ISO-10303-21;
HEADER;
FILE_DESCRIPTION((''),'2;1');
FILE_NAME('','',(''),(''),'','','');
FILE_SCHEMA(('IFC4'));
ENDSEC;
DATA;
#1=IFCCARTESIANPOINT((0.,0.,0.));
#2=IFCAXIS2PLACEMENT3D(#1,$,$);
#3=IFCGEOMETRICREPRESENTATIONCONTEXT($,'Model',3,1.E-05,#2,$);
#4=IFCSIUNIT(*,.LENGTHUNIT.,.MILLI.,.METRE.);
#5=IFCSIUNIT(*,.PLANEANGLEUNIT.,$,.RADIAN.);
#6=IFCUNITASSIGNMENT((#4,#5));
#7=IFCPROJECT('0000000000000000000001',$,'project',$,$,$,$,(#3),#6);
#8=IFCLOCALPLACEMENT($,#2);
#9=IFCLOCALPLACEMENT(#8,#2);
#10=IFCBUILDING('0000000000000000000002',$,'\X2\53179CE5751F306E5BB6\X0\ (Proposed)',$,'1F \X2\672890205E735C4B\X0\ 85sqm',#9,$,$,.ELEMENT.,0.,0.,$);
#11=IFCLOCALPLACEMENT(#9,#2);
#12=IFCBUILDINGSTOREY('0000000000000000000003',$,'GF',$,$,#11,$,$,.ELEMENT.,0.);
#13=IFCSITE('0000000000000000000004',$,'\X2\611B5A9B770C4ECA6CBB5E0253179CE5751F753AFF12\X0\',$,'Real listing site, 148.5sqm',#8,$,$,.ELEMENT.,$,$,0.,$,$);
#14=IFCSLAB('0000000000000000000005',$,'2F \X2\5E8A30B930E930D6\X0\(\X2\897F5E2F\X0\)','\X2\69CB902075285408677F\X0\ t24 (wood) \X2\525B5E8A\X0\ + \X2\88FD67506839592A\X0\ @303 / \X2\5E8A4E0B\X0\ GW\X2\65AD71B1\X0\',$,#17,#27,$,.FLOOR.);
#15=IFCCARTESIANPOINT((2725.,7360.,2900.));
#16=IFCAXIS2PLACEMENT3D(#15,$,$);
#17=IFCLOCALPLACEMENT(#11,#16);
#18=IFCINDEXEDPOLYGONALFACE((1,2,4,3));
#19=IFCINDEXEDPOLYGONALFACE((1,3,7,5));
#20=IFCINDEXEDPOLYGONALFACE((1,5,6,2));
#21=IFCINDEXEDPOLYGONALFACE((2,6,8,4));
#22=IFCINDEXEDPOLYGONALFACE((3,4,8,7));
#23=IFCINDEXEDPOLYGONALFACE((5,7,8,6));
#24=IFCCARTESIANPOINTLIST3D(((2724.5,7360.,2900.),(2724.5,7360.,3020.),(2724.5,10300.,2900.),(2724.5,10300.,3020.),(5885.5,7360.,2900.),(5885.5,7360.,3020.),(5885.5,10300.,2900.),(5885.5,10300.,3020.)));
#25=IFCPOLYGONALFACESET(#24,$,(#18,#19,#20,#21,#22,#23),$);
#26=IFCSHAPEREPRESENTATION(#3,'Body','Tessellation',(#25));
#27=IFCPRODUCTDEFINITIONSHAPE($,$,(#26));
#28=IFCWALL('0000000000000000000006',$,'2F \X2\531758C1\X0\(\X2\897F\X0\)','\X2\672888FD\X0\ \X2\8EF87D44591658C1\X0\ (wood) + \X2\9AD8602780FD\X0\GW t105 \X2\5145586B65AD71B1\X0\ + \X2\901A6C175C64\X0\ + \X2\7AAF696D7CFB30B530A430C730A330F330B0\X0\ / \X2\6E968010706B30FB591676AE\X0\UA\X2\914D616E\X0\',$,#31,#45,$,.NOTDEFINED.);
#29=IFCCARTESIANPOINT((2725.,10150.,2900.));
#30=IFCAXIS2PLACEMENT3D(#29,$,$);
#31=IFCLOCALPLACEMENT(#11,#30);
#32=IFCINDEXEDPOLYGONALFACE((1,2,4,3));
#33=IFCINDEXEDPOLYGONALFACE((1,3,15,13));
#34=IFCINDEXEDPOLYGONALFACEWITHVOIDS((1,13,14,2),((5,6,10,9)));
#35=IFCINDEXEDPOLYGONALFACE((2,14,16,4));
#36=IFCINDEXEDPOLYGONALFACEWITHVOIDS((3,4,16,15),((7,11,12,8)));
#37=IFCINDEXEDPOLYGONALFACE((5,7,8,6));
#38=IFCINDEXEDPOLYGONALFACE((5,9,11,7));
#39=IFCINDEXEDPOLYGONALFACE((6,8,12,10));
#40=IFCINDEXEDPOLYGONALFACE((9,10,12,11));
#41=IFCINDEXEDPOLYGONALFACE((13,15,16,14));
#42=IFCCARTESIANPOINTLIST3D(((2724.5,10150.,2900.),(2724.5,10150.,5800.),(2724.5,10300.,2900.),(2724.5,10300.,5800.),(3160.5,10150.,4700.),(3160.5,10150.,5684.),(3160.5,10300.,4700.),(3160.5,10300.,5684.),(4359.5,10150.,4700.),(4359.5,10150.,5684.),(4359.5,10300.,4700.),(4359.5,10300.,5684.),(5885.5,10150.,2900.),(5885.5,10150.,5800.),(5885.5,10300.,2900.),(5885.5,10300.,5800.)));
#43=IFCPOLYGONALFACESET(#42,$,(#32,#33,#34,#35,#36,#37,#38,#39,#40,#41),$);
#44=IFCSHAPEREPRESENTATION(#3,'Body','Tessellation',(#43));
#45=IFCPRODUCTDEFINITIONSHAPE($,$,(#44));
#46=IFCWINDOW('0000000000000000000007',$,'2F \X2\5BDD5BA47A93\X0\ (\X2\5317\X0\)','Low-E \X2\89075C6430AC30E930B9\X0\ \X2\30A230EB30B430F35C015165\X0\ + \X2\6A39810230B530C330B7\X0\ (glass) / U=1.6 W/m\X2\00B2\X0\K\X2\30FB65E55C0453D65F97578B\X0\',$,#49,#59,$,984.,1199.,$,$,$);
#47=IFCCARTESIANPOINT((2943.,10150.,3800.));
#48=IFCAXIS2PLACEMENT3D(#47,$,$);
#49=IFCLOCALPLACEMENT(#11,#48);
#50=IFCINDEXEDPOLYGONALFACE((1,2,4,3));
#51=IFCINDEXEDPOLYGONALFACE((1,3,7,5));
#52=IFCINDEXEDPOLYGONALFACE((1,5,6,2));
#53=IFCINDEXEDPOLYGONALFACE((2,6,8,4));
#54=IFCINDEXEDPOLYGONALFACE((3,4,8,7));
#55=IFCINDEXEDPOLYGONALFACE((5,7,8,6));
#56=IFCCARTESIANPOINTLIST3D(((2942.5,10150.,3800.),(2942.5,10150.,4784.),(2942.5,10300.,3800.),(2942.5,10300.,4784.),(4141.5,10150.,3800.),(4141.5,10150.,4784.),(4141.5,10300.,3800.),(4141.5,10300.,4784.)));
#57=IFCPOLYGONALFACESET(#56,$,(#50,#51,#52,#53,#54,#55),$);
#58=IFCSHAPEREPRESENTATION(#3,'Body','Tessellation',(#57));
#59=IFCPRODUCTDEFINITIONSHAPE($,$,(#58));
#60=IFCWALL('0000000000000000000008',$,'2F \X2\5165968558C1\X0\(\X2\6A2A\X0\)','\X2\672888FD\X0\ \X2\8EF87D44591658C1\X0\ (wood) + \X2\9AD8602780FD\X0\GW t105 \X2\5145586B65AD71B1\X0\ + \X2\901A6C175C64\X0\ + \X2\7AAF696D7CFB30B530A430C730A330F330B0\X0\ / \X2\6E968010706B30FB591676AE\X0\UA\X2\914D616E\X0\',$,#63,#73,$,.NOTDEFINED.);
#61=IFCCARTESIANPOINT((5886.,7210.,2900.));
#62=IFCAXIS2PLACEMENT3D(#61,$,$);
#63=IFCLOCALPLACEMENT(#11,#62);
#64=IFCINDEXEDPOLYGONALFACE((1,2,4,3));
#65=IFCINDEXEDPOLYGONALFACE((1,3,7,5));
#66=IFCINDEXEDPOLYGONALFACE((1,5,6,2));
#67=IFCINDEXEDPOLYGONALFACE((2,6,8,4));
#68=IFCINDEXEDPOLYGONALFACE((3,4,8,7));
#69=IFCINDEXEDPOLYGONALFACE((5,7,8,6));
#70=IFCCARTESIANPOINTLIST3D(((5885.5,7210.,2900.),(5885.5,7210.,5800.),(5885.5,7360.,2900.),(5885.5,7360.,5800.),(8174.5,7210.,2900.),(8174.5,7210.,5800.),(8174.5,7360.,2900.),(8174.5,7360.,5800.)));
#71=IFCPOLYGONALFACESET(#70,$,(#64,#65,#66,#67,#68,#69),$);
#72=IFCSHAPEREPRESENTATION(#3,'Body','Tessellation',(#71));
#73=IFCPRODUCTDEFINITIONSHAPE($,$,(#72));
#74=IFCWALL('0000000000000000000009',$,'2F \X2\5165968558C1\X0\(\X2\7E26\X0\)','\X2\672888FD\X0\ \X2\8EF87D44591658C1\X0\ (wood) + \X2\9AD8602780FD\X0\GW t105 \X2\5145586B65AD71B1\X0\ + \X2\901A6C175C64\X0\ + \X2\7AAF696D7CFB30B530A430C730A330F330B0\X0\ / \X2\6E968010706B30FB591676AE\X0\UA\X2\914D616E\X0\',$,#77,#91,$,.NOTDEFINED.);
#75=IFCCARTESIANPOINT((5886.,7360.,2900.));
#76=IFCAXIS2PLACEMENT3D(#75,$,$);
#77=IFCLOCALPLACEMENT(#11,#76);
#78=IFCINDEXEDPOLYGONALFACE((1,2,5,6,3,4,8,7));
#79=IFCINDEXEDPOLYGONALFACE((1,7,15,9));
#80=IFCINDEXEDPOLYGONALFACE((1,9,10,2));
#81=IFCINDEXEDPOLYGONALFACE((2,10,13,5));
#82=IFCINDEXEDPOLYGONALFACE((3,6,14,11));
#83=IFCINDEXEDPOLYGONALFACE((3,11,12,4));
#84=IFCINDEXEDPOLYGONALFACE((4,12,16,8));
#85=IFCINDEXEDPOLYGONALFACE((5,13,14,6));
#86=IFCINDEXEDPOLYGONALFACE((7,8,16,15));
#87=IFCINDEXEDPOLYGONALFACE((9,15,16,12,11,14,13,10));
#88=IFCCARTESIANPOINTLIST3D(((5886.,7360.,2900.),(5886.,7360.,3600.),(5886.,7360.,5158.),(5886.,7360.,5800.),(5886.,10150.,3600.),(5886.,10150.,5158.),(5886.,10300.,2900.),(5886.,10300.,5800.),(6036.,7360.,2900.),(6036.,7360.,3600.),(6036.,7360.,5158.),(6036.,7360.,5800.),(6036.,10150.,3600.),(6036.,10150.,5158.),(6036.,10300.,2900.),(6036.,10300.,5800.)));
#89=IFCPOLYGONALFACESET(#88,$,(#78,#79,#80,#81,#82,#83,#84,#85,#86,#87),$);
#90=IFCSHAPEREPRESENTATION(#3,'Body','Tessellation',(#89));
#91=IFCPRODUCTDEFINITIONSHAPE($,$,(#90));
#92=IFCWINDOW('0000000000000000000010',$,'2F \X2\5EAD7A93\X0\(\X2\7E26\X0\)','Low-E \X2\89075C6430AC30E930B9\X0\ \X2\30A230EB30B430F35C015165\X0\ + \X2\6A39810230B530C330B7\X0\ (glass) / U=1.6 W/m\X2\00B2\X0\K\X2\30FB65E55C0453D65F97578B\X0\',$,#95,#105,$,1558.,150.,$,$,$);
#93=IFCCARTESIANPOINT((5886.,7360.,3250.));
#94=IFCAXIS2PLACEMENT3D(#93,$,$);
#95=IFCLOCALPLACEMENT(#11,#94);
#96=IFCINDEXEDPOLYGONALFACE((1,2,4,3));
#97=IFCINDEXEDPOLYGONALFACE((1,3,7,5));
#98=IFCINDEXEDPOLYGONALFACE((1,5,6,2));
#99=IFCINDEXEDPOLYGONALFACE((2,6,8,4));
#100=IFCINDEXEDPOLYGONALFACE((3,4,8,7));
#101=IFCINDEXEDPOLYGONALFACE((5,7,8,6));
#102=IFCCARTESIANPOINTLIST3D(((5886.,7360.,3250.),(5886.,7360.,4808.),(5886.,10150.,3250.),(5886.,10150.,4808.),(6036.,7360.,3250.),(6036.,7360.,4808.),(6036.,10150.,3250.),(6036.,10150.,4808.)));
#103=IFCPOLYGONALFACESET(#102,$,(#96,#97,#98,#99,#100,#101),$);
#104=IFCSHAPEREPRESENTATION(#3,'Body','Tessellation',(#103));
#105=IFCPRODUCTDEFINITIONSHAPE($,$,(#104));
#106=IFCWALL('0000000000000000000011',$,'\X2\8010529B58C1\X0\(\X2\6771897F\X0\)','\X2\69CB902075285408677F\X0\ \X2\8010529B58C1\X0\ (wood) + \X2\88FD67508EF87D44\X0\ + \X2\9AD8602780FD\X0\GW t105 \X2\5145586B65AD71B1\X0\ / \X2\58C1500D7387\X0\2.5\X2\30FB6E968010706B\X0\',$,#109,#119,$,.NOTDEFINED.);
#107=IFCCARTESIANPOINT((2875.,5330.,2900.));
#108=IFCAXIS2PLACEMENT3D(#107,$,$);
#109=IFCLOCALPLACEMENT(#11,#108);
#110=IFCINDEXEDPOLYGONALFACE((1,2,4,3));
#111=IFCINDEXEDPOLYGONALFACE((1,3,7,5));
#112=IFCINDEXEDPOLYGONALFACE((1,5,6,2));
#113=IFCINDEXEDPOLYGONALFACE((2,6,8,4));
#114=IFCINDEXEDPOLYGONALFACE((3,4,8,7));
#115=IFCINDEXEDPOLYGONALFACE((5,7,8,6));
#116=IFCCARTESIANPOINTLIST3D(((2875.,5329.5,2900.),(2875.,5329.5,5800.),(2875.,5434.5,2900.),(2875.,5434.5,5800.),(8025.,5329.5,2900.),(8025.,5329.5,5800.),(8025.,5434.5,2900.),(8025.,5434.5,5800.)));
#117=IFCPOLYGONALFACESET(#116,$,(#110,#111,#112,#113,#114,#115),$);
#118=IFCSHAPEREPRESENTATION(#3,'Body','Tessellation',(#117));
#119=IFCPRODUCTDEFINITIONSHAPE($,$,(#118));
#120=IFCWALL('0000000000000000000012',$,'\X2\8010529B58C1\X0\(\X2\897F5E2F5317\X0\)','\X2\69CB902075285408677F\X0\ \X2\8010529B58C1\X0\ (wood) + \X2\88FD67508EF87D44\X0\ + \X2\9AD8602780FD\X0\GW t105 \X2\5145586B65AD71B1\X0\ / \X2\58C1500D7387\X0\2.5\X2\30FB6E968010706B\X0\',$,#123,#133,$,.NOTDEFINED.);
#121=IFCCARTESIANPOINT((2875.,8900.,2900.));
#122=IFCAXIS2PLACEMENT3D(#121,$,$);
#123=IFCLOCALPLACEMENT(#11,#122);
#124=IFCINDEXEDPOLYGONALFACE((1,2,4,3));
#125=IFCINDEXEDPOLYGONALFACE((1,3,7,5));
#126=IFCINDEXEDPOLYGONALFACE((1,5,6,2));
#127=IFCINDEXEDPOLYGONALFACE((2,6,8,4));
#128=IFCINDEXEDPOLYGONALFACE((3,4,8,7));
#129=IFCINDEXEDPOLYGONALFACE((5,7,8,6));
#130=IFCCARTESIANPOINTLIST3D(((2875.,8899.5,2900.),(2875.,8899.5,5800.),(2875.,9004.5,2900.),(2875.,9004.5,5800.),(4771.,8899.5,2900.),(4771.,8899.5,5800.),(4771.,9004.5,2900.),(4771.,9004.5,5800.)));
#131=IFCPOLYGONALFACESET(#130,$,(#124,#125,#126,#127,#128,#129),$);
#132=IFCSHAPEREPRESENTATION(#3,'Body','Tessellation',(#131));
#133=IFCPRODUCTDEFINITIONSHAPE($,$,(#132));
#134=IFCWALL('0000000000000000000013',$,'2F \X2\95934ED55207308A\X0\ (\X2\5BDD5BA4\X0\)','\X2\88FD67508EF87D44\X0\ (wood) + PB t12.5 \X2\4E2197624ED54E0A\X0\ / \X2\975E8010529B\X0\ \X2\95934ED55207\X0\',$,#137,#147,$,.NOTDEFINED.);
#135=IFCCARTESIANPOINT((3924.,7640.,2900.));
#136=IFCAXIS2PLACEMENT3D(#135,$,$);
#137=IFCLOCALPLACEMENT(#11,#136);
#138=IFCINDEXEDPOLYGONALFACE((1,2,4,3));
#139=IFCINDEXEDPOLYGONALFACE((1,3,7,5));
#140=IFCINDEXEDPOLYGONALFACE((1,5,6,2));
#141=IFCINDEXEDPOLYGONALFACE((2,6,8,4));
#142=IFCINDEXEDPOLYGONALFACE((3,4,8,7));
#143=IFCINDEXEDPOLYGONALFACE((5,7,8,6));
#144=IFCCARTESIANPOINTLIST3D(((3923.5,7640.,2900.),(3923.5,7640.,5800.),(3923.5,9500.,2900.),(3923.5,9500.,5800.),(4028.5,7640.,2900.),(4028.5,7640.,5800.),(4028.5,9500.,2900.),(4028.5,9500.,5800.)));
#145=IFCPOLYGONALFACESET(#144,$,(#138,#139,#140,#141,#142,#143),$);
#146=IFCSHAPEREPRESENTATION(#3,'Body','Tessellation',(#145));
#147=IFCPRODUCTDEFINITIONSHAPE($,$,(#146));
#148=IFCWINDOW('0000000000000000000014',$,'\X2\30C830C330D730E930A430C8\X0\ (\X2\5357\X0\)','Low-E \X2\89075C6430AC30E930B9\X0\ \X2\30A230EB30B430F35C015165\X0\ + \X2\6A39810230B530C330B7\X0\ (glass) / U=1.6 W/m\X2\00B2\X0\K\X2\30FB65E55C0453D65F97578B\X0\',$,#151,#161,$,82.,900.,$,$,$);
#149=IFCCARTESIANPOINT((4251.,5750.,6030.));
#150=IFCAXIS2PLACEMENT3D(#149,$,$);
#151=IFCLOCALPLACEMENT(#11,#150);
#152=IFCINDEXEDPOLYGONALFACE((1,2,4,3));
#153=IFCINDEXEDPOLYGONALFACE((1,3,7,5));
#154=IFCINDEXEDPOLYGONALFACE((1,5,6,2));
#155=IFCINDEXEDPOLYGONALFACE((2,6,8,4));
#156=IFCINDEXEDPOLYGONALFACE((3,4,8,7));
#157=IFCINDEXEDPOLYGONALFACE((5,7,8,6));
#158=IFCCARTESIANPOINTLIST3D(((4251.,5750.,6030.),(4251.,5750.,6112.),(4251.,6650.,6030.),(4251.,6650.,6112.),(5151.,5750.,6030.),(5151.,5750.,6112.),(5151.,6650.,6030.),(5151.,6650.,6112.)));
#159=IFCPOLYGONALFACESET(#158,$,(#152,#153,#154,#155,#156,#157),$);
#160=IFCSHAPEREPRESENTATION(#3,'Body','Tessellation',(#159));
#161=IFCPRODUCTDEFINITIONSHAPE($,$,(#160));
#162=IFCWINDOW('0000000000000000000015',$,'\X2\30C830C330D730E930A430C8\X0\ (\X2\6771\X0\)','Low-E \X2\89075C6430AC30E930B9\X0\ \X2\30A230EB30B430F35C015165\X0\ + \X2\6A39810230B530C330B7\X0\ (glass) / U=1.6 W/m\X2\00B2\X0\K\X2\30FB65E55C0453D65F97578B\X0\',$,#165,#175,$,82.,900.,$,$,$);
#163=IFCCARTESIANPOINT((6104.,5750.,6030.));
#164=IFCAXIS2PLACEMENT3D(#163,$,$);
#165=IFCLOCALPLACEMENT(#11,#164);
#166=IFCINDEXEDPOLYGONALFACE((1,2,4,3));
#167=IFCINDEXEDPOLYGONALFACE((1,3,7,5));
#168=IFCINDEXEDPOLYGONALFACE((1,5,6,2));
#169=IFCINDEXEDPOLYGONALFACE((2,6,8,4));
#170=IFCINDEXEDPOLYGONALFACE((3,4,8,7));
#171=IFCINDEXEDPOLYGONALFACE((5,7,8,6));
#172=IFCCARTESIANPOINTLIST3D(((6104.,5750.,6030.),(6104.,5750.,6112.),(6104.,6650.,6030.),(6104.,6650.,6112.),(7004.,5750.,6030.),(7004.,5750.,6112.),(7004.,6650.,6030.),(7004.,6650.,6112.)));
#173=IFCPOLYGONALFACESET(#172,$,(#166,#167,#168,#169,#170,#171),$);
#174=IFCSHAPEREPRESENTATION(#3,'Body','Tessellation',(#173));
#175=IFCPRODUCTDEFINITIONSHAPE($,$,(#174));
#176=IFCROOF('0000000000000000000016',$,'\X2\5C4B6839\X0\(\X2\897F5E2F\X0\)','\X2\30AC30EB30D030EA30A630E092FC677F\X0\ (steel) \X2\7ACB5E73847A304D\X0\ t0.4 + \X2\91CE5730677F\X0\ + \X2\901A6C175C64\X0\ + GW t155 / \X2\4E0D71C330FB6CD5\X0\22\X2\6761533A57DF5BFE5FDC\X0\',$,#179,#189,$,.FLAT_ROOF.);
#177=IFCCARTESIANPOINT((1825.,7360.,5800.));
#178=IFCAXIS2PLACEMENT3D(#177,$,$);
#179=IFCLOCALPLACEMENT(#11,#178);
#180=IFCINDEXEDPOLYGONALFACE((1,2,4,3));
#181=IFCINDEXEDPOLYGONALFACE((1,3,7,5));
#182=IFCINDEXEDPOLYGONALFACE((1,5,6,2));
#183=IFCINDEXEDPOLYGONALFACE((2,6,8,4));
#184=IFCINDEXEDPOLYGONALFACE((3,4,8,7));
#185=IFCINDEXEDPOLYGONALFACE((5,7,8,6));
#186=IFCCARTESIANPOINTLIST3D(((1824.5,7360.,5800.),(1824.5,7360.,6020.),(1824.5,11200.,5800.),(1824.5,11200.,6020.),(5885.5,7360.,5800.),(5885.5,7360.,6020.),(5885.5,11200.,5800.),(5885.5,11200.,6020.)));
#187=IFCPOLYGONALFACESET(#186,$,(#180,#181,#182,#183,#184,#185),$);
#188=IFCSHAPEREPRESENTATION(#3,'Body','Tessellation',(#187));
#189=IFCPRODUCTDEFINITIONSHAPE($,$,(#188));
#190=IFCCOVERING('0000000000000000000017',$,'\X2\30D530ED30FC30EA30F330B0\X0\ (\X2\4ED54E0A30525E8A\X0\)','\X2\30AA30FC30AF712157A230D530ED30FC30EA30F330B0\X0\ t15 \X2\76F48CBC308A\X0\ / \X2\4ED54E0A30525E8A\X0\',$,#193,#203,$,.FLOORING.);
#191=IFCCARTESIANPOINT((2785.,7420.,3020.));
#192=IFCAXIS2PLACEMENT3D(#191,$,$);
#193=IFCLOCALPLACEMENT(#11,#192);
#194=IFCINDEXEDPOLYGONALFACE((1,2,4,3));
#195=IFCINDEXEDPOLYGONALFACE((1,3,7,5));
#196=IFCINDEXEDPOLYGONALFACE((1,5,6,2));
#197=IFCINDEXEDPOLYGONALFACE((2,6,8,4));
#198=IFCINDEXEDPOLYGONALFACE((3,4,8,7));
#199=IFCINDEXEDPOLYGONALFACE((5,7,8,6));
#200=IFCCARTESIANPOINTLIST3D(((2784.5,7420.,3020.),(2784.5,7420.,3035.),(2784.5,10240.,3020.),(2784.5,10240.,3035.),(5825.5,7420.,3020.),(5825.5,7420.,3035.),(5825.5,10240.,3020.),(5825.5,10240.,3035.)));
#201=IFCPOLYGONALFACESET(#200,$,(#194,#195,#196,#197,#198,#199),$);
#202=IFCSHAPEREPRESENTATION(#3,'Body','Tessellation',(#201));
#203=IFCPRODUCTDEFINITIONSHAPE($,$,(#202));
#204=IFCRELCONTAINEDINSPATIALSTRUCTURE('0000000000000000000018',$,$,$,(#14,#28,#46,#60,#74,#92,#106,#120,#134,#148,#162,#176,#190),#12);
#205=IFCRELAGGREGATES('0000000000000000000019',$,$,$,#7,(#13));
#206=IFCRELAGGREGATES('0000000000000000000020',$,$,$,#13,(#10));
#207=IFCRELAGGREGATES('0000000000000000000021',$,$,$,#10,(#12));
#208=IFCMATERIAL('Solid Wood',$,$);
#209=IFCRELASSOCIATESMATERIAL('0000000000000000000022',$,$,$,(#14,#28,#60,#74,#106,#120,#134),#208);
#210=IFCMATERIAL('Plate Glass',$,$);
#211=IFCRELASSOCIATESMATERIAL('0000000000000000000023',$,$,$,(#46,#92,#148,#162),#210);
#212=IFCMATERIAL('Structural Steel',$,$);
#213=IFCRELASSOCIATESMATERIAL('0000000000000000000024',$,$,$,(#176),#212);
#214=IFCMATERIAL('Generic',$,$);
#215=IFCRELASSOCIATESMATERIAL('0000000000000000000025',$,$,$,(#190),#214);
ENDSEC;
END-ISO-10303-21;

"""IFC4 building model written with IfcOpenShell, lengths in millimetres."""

from ifc_helpers import new_model, si_unit, frame, frame_2d, origin, place, context, project, spatial, rectangle, extrude, material, element, fill, save


model = new_model("IFC4")

# Units and contexts
model_context = context("Model", 3, precision=1e-05, world=origin())
ifc_project = project(units=[si_unit("LENGTHUNIT", "METRE", prefix="MILLI"), si_unit("PLANEANGLEUNIT", "RADIAN")], contexts=[model_context])

# Site, building, storey
site_placement = place(None, origin())
site = spatial("IfcSite", under=ifc_project, at=site_placement, Name="愛媛県今治市北鳥生町２", ObjectType="Real listing site, 148.5sqm", CompositionType="ELEMENT", RefElevation=0.0)
building_placement = place(site_placement, origin())
building = spatial("IfcBuilding", under=site, at=building_placement, Name="北鳥生の家 (Proposed)", ObjectType="1F 木造平屋 85sqm", CompositionType="ELEMENT", ElevationOfRefHeight=0.0, ElevationOfTerrain=0.0)
storey_placement = place(building_placement, origin())
storey = spatial("IfcBuildingStorey", under=building, at=storey_placement, Name="GF", CompositionType="ELEMENT", Elevation=0.0)

# Slab
ifc_material_1 = material(Name="Solid Wood")
slab_placement = place(storey_placement, frame((2725.0, 7360.0, 2900.0)))
element("IfcSlab", 1, at=slab_placement, inside=storey, material=ifc_material_1, Name="2F 床スラブ(西帯)", Description="構造用合板 t24 (wood) 剛床 + 製材根太 @303 / 床下 GW断熱", PredefinedType="FLOOR", context=model_context, shape_type="SweptSolid", body=[
    extrude(rectangle(XDim=3161.0, YDim=2940.0, at=frame_2d((1580.0, 1470.0))), frame((2725.0, 7360.0, 2900.0)), (0.0, 0.0, 1.0), 120.0),
])

# Wall, opening, window
wall_1_placement = place(storey_placement, frame((2725.0, 10150.0, 2900.0)))
wall_1 = element("IfcWall", 2, at=wall_1_placement, inside=storey, material=ifc_material_1, Name="2F 北壁(西)", Description="木製 軸組外壁 (wood) + 高性能GW t105 充填断熱 + 通気層 + 窯業系サイディング / 準耐火・外皮UA配慮", PredefinedType="NOTDEFINED", context=model_context, shape_type="SweptSolid", body=[
    extrude(rectangle(XDim=3161.0, YDim=150.0, at=frame_2d((1580.0, 75.0))), frame((2725.0, 10150.0, 2900.0)), (0.0, 0.0, 1.0), 2900.0),
])
opening_1_placement = place(storey_placement, frame((2943.0, 10150.0, 3800.0)))
opening_1 = element("IfcOpeningElement", 3, at=opening_1_placement, cuts=wall_1, PredefinedType="NOTDEFINED", context=model_context, shape_type="SweptSolid", body=[
    extrude(rectangle(XDim=1199.0, YDim=150.0, at=frame_2d((599.0, 75.0))), frame((2943.0, 10150.0, 3800.0)), (0.0, 0.0, 1.0), 984.0),
])
ifc_material_2 = material(Name="Plate Glass")
window_1_placement = place(storey_placement, frame((2943.0, 10150.0, 3800.0)))
window_1 = element("IfcWindow", 4, at=window_1_placement, inside=storey, material=ifc_material_2, Name="2F 寝室窓 (北)", Description="Low-E 複層ガラス アルゴン封入 + 樹脂サッシ (glass) / U=1.6 W/m²K・日射取得型", OverallHeight=984.0, OverallWidth=1199.0, context=model_context, shape_type="SweptSolid", body=[
    extrude(rectangle(XDim=1199.0, YDim=150.0, at=frame_2d((599.0, 75.0))), frame((2943.0, 10150.0, 3800.0)), (0.0, 0.0, 1.0), 984.0),
])
fill(opening_1, window_1)

# Wall
wall_2_placement = place(storey_placement, frame((5886.0, 7210.0, 2900.0)))
element("IfcWall", 5, at=wall_2_placement, inside=storey, material=ifc_material_1, Name="2F 入隅壁(横)", Description="木製 軸組外壁 (wood) + 高性能GW t105 充填断熱 + 通気層 + 窯業系サイディング / 準耐火・外皮UA配慮", PredefinedType="NOTDEFINED", context=model_context, shape_type="SweptSolid", body=[
    extrude(rectangle(XDim=2289.0, YDim=150.0, at=frame_2d((1144.0, 75.0))), frame((5886.0, 7210.0, 2900.0)), (0.0, 0.0, 1.0), 2900.0),
])

# Wall, opening, window
wall_3_placement = place(storey_placement, frame((5886.0, 7360.0, 2900.0)))
wall_3 = element("IfcWall", 6, at=wall_3_placement, inside=storey, material=ifc_material_1, Name="2F 入隅壁(縦)", Description="木製 軸組外壁 (wood) + 高性能GW t105 充填断熱 + 通気層 + 窯業系サイディング / 準耐火・外皮UA配慮", PredefinedType="NOTDEFINED", context=model_context, shape_type="SweptSolid", body=[
    extrude(rectangle(XDim=150.0, YDim=2940.0, at=frame_2d((75.0, 1470.0))), frame((5886.0, 7360.0, 2900.0)), (0.0, 0.0, 1.0), 2900.0),
])
opening_2_placement = place(storey_placement, frame((5886.0, 7360.0, 3250.0)))
opening_2 = element("IfcOpeningElement", 7, at=opening_2_placement, cuts=wall_3, PredefinedType="NOTDEFINED", context=model_context, shape_type="SweptSolid", body=[
    extrude(rectangle(XDim=150.0, YDim=2790.0, at=frame_2d((75.0, 1395.0))), frame((5886.0, 7360.0, 3250.0)), (0.0, 0.0, 1.0), 1558.0),
])
window_2_placement = place(storey_placement, frame((5886.0, 7360.0, 3250.0)))
window_2 = element("IfcWindow", 8, at=window_2_placement, inside=storey, material=ifc_material_2, Name="2F 庭窓(縦)", Description="Low-E 複層ガラス アルゴン封入 + 樹脂サッシ (glass) / U=1.6 W/m²K・日射取得型", OverallHeight=1558.0, OverallWidth=150.0, context=model_context, shape_type="SweptSolid", body=[
    extrude(rectangle(XDim=150.0, YDim=2790.0, at=frame_2d((75.0, 1395.0))), frame((5886.0, 7360.0, 3250.0)), (0.0, 0.0, 1.0), 1558.0),
])
fill(opening_2, window_2)

# Walls
wall_4_placement = place(storey_placement, frame((2875.0, 5330.0, 2900.0)))
element("IfcWall", 9, at=wall_4_placement, inside=storey, material=ifc_material_1, Name="耐力壁(東西)", Description="構造用合板 耐力壁 (wood) + 製材軸組 + 高性能GW t105 充填断熱 / 壁倍率2.5・準耐火", PredefinedType="NOTDEFINED", context=model_context, shape_type="SweptSolid", body=[
    extrude(rectangle(XDim=5150.0, YDim=105.0, at=frame_2d((2575.0, 52.0))), frame((2875.0, 5330.0, 2900.0)), (0.0, 0.0, 1.0), 2900.0),
])
wall_5_placement = place(storey_placement, frame((2875.0, 8900.0, 2900.0)))
element("IfcWall", 10, at=wall_5_placement, inside=storey, material=ifc_material_1, Name="耐力壁(西帯北)", Description="構造用合板 耐力壁 (wood) + 製材軸組 + 高性能GW t105 充填断熱 / 壁倍率2.5・準耐火", PredefinedType="NOTDEFINED", context=model_context, shape_type="SweptSolid", body=[
    extrude(rectangle(XDim=1896.0, YDim=105.0, at=frame_2d((948.0, 52.0))), frame((2875.0, 8900.0, 2900.0)), (0.0, 0.0, 1.0), 2900.0),
])
wall_6_placement = place(storey_placement, frame((3924.0, 7640.0, 2900.0)))
element("IfcWall", 11, at=wall_6_placement, inside=storey, material=ifc_material_1, Name="2F 間仕切り (寝室)", Description="製材軸組 (wood) + PB t12.5 両面仕上 / 非耐力 間仕切", PredefinedType="NOTDEFINED", context=model_context, shape_type="SweptSolid", body=[
    extrude(rectangle(XDim=105.0, YDim=1860.0, at=frame_2d((52.0, 930.0))), frame((3924.0, 7640.0, 2900.0)), (0.0, 0.0, 1.0), 2900.0),
])

# Windows
window_3_placement = place(storey_placement, frame((4251.0, 5750.0, 6030.0)))
element("IfcWindow", 12, at=window_3_placement, inside=storey, material=ifc_material_2, Name="トップライト (南)", Description="Low-E 複層ガラス アルゴン封入 + 樹脂サッシ (glass) / U=1.6 W/m²K・日射取得型", OverallHeight=82.0, OverallWidth=900.0, context=model_context, shape_type="SweptSolid", body=[
    extrude(rectangle(XDim=900.0, YDim=900.0, at=frame_2d((450.0, 450.0))), frame((4251.0, 5750.0, 6030.0)), (0.0, 0.0, 1.0), 82.0),
])
window_4_placement = place(storey_placement, frame((6104.0, 5750.0, 6030.0)))
element("IfcWindow", 13, at=window_4_placement, inside=storey, material=ifc_material_2, Name="トップライト (東)", Description="Low-E 複層ガラス アルゴン封入 + 樹脂サッシ (glass) / U=1.6 W/m²K・日射取得型", OverallHeight=82.0, OverallWidth=900.0, context=model_context, shape_type="SweptSolid", body=[
    extrude(rectangle(XDim=900.0, YDim=900.0, at=frame_2d((450.0, 450.0))), frame((6104.0, 5750.0, 6030.0)), (0.0, 0.0, 1.0), 82.0),
])

# Roof
ifc_material_3 = material(Name="Structural Steel")
for number, where, name in (
    (14, (1825.0, 7360.0, 5800.0), "屋根(西帯)"),
):
    element("IfcRoof", number, at=place(storey_placement, frame(where)), inside=storey, material=ifc_material_3, Name=name, Description="ガルバリウム鋼板 (steel) 立平葺き t0.4 + 野地板 + 通気層 + GW t155 / 不燃・法22条区域対応", PredefinedType="FLAT_ROOF", context=model_context, shape_type="SweptSolid", body=[
        extrude(rectangle(XDim=4061.0, YDim=3840.0, at=frame_2d((2030.0, 1920.0))), frame((1825.0, 7360.0, 5800.0)), (0.0, 0.0, 1.0), 220.0),
    ])

# Covering
ifc_material_4 = material(Name="Generic")
covering_placement = place(storey_placement, frame((2785.0, 7420.0, 3020.0)))
element("IfcCovering", 15, at=covering_placement, inside=storey, material=ifc_material_4, Name="フローリング (仕上げ床)", Description="オーク無垢フローリング t15 直貼り / 仕上げ床", PredefinedType="FLOORING", context=model_context, shape_type="SweptSolid", body=[
    extrude(rectangle(XDim=3041.0, YDim=2820.0, at=frame_2d((1520.0, 1410.0))), frame((2785.0, 7420.0, 3020.0)), (0.0, 0.0, 1.0), 15.0),
])

save(model, "model.ifc")
